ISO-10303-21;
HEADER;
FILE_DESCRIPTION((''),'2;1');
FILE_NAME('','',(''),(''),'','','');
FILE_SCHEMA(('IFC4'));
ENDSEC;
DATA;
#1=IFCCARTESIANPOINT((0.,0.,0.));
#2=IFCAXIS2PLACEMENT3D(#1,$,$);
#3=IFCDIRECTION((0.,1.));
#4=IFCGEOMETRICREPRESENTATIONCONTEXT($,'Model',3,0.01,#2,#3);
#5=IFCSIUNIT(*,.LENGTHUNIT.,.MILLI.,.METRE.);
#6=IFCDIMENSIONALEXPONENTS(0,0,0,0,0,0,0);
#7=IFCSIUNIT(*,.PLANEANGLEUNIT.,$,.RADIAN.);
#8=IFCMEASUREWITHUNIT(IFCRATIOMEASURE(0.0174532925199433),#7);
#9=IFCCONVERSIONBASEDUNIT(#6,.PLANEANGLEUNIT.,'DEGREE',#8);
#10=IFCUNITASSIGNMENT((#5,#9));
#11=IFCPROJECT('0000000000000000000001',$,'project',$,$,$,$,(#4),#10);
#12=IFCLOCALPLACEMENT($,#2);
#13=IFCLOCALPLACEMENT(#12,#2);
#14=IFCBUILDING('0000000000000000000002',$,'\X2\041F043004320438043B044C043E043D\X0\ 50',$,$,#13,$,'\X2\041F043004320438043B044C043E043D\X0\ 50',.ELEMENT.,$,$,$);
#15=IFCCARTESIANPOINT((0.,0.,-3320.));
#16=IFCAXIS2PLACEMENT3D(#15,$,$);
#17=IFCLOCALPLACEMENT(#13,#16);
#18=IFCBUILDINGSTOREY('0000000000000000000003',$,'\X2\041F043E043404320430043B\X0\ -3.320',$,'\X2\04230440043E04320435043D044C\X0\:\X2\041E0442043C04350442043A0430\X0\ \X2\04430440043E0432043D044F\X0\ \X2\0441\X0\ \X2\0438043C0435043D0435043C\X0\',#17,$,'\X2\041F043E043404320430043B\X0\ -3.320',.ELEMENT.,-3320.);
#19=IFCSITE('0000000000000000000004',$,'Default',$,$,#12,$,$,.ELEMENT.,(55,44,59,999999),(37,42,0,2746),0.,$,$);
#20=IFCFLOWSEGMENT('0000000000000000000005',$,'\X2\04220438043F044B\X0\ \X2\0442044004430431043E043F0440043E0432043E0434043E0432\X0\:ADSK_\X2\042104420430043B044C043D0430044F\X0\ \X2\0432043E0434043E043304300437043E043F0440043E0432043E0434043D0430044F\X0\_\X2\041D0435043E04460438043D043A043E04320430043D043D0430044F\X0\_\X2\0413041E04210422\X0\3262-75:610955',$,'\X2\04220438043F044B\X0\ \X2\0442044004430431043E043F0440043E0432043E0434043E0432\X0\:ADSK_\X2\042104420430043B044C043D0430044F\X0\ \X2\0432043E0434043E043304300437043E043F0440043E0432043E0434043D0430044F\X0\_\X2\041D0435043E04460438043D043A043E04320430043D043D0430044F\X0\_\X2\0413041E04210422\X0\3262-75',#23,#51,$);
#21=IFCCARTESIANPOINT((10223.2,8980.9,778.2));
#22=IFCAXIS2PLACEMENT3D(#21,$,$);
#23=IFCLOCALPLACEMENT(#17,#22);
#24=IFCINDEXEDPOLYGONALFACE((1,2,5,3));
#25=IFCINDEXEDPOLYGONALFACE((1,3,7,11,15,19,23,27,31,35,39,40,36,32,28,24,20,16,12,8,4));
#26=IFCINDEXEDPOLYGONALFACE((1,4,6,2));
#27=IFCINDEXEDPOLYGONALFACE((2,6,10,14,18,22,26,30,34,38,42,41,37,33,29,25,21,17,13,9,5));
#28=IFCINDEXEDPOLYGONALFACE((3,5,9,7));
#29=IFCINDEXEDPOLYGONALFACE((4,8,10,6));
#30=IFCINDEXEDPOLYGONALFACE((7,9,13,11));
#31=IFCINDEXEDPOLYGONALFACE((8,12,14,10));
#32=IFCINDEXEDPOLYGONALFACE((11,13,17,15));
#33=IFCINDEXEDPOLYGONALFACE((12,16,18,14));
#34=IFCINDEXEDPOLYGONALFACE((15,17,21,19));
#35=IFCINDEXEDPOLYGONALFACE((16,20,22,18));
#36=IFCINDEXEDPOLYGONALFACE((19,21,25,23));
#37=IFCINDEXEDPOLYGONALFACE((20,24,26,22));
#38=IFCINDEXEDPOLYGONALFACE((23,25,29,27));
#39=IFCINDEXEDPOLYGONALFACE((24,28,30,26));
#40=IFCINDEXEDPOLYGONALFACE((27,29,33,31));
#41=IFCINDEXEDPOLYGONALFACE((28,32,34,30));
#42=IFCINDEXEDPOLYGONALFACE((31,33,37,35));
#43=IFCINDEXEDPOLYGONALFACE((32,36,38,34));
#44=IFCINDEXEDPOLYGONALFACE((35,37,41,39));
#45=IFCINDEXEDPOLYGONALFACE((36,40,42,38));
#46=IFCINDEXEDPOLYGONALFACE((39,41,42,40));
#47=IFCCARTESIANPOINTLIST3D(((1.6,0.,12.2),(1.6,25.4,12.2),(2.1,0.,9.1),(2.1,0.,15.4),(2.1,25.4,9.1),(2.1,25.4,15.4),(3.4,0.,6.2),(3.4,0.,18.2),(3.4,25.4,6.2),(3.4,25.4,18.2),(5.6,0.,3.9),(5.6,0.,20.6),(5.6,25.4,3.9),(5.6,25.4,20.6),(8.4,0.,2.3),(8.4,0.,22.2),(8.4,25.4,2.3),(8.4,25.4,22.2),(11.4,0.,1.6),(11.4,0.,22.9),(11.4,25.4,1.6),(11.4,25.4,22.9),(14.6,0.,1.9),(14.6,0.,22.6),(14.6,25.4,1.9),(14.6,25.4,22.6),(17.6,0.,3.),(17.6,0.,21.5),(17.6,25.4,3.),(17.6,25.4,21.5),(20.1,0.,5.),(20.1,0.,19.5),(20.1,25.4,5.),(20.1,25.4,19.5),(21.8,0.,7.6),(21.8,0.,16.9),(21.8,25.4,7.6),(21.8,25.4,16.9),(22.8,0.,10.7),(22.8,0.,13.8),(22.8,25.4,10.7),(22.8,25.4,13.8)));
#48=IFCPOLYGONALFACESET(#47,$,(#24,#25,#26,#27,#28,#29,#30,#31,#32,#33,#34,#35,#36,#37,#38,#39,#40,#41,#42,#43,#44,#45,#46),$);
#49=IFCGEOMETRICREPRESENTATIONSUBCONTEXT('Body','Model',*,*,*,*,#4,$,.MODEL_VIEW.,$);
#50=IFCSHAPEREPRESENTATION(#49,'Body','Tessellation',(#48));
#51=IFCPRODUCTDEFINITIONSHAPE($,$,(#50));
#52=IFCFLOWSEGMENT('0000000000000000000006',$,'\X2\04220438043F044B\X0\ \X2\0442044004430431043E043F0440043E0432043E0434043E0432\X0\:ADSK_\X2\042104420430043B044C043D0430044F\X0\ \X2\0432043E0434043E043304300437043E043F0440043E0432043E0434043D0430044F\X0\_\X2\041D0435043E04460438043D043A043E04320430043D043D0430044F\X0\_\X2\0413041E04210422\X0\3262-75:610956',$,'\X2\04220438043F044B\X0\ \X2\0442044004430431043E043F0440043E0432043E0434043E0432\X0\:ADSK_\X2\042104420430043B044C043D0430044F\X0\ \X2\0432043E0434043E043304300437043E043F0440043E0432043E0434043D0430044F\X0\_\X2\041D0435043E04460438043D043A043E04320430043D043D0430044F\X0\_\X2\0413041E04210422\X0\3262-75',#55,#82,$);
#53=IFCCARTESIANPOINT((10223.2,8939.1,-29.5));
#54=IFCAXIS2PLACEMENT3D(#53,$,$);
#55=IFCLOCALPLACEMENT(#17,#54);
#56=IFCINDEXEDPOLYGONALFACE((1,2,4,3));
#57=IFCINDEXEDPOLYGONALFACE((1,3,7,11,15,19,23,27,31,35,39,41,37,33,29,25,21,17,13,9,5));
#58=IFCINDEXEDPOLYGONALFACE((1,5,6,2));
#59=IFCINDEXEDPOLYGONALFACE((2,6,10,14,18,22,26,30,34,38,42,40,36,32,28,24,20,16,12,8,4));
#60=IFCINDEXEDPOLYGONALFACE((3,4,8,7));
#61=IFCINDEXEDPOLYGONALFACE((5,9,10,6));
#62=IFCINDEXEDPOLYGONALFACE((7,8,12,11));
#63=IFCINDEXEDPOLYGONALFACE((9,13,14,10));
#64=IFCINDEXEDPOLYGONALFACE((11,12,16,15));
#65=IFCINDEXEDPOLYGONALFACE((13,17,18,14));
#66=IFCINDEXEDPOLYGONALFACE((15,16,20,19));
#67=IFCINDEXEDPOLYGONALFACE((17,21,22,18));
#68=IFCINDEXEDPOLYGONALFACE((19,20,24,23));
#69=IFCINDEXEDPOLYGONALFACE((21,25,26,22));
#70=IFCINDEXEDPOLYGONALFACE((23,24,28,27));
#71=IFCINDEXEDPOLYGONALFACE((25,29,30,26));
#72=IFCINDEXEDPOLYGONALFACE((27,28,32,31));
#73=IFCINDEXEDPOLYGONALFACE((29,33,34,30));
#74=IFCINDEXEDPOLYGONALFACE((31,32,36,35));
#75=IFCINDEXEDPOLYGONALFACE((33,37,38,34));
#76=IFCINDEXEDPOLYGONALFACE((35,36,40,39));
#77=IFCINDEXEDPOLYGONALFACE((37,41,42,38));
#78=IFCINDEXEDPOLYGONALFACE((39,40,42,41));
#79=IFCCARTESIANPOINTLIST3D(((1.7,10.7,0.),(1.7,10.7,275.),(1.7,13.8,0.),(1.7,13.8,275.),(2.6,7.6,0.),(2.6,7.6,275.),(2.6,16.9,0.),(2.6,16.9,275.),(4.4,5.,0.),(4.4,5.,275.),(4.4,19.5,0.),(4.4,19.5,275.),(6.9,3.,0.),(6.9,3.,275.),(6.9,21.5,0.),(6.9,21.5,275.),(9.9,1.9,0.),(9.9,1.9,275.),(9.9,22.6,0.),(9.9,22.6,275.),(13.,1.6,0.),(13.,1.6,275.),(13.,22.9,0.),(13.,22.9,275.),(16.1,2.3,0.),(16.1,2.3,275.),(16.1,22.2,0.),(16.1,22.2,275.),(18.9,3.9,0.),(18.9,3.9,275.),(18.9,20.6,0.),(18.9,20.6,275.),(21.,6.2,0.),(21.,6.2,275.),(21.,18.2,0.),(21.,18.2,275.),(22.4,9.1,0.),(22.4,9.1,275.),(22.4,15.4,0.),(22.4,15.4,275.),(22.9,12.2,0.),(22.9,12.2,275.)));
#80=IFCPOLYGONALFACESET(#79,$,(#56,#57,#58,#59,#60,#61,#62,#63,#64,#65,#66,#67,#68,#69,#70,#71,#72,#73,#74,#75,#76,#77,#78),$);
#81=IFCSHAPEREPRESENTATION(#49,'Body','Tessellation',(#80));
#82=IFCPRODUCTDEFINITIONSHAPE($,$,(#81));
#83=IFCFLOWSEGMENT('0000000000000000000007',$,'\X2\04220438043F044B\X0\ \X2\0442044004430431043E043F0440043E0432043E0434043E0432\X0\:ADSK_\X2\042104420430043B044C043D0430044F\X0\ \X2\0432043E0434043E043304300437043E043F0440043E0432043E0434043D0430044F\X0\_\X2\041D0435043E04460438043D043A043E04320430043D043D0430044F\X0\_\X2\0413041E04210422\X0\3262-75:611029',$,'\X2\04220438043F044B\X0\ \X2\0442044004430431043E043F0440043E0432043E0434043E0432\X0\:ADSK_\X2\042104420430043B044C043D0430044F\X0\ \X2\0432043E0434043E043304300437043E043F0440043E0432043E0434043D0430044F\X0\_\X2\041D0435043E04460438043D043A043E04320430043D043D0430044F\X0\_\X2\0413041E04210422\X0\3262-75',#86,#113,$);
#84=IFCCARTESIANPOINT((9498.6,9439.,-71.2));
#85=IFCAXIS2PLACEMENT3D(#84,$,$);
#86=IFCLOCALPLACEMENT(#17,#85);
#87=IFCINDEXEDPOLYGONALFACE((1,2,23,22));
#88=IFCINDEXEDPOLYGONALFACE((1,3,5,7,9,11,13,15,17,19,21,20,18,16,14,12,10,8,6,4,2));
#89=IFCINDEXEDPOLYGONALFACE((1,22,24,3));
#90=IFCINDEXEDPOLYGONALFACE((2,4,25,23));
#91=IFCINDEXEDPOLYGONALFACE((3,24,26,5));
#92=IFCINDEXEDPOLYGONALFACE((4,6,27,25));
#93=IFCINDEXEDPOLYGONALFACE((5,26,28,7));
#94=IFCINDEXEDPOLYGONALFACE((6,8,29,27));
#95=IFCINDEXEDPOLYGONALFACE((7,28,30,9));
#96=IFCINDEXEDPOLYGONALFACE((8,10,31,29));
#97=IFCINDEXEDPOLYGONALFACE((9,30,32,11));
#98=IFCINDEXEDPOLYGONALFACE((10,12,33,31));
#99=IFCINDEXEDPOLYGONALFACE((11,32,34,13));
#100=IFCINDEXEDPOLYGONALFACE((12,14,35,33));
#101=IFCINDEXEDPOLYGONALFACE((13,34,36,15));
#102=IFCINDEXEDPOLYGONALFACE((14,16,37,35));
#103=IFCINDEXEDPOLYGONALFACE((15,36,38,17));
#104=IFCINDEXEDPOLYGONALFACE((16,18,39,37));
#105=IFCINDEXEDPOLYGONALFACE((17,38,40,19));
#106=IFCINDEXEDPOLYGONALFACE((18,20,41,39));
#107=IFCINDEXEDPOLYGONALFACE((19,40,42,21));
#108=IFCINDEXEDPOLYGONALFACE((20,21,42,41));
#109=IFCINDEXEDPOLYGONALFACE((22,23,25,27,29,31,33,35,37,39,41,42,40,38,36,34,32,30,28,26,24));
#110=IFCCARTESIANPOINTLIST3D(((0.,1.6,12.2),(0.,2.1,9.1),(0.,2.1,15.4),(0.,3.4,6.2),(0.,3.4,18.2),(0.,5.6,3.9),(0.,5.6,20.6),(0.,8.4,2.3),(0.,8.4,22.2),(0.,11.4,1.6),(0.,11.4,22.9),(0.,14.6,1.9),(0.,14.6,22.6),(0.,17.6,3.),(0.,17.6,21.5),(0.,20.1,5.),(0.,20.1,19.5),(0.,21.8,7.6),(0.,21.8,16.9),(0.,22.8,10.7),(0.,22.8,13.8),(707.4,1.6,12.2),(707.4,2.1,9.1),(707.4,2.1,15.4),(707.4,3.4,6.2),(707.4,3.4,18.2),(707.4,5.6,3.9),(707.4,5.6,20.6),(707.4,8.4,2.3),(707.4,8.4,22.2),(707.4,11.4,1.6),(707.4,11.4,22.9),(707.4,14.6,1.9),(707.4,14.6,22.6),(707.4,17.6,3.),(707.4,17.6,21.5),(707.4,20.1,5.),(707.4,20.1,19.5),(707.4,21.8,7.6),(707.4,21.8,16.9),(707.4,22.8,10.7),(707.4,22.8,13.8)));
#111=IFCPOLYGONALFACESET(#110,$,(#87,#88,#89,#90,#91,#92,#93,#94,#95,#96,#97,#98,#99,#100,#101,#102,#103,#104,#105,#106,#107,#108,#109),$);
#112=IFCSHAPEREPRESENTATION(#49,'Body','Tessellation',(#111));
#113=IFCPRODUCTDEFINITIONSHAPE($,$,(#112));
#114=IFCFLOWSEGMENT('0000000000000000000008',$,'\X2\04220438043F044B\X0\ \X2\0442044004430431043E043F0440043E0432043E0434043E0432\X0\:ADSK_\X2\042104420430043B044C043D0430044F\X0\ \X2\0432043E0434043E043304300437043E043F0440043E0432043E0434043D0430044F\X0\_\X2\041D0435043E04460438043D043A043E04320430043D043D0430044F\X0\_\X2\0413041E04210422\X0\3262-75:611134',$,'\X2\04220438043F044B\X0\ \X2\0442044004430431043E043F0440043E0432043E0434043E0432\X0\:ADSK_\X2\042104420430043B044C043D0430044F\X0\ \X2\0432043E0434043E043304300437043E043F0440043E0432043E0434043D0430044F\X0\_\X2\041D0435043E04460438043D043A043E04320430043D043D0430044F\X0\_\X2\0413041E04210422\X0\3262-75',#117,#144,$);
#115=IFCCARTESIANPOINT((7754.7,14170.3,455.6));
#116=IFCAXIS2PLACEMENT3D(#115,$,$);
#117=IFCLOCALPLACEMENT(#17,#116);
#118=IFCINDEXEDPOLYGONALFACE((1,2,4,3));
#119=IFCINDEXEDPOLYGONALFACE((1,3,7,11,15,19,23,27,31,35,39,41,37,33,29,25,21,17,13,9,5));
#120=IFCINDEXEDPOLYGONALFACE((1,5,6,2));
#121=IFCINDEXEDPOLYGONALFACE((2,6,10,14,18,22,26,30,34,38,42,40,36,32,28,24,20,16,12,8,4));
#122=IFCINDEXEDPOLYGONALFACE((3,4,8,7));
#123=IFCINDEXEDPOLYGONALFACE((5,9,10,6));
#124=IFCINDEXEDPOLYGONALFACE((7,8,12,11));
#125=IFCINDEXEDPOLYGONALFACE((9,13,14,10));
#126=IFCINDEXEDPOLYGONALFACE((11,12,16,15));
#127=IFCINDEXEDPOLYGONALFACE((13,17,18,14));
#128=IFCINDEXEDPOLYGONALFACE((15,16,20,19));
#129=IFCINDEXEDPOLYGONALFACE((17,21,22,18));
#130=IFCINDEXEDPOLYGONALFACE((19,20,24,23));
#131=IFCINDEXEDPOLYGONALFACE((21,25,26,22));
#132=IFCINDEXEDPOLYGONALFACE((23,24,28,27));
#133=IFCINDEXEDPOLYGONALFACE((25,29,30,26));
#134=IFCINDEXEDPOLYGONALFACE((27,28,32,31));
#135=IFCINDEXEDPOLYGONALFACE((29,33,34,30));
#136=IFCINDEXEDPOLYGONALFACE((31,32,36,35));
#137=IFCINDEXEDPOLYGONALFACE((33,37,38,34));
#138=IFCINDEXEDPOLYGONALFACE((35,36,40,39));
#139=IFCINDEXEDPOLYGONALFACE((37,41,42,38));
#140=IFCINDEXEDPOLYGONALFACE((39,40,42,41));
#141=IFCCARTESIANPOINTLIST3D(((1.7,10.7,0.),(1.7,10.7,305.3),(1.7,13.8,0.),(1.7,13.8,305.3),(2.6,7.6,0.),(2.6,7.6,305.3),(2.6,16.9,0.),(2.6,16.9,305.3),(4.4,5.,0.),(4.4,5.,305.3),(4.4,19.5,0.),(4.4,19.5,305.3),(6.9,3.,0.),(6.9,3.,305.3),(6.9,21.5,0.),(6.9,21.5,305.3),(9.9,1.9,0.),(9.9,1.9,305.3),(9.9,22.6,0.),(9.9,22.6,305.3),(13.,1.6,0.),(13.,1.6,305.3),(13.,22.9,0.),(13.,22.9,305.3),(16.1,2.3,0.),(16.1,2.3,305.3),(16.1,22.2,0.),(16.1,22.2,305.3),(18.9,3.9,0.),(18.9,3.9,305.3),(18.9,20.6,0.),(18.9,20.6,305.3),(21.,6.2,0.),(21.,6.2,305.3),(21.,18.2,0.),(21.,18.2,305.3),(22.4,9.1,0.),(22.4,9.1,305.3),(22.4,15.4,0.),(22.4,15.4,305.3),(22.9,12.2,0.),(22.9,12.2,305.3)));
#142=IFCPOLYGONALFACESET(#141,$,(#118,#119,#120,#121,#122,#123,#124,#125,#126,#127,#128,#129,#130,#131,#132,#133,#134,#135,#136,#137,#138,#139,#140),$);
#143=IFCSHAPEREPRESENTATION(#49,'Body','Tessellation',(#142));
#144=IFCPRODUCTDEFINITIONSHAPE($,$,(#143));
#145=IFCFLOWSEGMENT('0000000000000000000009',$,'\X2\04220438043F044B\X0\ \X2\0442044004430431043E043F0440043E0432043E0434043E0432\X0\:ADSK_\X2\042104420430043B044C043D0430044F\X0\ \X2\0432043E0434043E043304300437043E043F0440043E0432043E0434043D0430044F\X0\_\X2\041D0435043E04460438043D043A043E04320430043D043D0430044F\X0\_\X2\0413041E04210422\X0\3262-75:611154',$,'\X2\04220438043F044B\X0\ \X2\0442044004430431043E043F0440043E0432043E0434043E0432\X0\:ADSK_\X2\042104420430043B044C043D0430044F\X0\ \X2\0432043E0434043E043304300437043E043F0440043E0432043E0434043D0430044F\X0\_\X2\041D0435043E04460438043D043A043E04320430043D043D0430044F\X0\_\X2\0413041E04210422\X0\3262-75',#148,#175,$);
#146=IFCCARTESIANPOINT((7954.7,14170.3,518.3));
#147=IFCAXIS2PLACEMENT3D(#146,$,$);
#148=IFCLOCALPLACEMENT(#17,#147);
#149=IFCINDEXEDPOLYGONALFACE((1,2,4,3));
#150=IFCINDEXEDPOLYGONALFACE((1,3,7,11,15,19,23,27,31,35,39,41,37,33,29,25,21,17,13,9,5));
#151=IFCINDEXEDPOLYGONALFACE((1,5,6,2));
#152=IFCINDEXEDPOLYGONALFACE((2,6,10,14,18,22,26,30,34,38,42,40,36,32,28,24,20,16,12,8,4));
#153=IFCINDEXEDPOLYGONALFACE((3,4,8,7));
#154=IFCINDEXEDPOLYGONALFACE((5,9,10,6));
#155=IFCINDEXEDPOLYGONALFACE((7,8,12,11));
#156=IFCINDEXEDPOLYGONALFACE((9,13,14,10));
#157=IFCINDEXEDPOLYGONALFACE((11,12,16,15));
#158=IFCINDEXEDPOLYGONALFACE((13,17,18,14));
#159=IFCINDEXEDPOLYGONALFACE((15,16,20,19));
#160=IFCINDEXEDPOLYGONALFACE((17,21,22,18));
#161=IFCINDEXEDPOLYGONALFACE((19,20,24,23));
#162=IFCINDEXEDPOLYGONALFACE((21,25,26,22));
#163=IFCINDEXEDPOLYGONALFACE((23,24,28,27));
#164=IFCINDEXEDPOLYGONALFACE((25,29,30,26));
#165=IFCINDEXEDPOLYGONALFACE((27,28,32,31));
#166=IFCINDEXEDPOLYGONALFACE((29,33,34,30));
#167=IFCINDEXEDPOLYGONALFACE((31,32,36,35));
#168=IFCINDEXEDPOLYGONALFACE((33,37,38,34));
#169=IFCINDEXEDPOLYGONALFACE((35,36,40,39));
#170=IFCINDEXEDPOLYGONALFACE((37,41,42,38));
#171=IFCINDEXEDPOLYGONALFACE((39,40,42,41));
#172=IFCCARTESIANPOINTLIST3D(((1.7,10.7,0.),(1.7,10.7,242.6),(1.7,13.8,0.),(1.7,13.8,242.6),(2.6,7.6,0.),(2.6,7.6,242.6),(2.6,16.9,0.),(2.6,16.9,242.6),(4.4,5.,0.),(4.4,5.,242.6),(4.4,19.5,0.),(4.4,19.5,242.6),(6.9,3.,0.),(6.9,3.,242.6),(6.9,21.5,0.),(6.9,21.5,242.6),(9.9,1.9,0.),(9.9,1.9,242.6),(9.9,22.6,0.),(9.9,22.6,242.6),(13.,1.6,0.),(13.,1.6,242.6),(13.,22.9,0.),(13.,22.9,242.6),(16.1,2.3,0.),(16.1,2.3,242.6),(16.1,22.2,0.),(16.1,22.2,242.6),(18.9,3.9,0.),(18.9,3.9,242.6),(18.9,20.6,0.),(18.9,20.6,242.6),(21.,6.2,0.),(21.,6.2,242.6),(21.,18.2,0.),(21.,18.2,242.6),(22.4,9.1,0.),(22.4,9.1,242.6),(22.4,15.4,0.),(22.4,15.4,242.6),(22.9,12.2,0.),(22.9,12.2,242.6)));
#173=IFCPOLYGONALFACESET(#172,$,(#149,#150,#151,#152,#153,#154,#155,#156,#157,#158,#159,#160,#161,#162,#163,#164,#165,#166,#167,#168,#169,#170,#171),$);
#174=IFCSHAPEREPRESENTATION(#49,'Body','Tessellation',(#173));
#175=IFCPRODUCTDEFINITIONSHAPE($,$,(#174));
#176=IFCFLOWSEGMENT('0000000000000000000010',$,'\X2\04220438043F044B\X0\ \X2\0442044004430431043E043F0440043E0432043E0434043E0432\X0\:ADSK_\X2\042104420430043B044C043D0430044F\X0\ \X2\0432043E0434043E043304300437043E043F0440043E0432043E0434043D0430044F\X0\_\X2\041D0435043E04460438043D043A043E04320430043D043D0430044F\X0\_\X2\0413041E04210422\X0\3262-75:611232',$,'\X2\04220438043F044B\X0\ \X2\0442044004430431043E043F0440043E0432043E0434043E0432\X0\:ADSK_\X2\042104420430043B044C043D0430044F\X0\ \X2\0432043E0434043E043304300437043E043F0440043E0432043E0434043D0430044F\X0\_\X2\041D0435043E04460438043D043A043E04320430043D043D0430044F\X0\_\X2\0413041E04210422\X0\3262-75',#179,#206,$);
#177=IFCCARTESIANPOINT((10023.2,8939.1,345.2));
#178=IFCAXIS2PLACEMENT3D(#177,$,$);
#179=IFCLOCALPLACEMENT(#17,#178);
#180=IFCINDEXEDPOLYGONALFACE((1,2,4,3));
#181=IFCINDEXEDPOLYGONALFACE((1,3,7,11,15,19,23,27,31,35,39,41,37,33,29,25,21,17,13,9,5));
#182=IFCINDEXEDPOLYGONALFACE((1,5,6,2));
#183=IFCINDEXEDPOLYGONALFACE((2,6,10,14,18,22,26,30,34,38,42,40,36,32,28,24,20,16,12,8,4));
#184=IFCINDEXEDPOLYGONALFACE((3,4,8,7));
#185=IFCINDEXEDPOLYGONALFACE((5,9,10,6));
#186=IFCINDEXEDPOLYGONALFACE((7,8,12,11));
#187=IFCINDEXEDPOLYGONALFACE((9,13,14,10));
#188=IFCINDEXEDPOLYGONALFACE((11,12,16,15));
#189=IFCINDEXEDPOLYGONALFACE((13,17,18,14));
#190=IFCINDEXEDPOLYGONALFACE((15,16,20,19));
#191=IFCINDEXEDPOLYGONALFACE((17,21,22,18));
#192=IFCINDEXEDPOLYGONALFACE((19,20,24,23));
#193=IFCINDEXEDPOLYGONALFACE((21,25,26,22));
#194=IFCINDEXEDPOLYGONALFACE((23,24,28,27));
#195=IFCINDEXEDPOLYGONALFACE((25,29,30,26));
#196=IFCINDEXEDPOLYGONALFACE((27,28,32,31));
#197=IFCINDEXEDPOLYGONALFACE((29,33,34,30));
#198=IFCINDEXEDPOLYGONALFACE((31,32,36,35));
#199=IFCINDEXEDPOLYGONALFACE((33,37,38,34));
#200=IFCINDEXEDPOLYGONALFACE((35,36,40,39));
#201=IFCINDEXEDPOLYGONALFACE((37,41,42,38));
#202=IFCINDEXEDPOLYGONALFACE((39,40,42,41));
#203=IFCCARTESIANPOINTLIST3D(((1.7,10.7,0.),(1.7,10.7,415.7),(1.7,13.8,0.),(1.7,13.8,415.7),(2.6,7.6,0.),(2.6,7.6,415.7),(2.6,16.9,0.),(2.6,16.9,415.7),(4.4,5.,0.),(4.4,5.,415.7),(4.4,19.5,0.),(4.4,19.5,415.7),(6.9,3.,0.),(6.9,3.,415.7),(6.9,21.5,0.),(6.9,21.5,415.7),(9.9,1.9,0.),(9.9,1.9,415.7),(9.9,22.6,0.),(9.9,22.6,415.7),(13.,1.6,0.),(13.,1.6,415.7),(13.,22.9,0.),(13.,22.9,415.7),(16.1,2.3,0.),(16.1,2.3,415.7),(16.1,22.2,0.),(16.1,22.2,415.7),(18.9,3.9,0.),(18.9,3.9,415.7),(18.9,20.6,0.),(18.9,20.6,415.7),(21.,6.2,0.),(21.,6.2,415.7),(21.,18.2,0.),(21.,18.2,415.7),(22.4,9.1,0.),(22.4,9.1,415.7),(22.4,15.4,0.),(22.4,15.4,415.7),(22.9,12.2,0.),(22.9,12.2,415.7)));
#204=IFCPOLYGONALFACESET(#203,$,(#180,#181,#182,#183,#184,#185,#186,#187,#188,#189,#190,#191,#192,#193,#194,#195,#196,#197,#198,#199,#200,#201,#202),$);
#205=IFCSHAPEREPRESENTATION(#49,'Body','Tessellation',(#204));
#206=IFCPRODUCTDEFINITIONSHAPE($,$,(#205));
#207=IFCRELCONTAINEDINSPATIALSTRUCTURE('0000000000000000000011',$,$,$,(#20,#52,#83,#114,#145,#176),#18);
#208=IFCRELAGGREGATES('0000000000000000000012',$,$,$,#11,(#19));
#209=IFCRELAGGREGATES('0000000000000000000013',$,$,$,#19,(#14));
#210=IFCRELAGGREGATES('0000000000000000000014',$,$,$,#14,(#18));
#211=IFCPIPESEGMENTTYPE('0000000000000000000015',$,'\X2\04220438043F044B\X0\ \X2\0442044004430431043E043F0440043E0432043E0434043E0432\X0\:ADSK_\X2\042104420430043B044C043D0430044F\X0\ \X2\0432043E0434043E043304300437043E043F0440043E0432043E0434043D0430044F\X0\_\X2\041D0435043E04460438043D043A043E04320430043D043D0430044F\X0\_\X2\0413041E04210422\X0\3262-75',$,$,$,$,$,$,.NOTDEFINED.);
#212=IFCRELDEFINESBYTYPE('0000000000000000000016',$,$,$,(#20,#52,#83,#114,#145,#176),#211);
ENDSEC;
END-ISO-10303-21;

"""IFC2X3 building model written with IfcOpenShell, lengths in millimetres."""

from ifc_helpers import new_model, entity, si_unit, converted_unit, direction, frame, origin, origin_2d_with_axis, place, context, subcontext, project, spatial, circle, extrude, type_object, element, save


model = new_model("IFC2X3")

# Units and contexts
model_context = context("Model", 3, precision=0.01, world=origin(), true_north=direction((0.0, 1.0)))
body_context = subcontext(model_context, "Body", "Model", "MODEL_VIEW")
ifc_project = project(units=[si_unit("LENGTHUNIT", "METRE", prefix="MILLI"), converted_unit("PLANEANGLEUNIT", "DEGREE", entity("IfcRatioMeasure", 0.0174532925199433), si_unit("PLANEANGLEUNIT", "RADIAN"), dimensions=[0, 0, 0, 0, 0, 0, 0])], contexts=[model_context])

# Site, building, storey
site_placement = place(None, origin())
site = spatial("IfcSite", under=ifc_project, at=site_placement, Name="Default", CompositionType="ELEMENT", RefLatitude=(55, 44, 59, 999999), RefLongitude=(37, 42, 0, 2746), RefElevation=0.0)
building_placement = place(site_placement, origin())
building = spatial("IfcBuilding", under=site, at=building_placement, Name="Павильон 50", LongName="Павильон 50", CompositionType="ELEMENT")
storey_placement = place(building_placement, frame((0.0, 0.0, -3320.0)))
storey = spatial("IfcBuildingStorey", under=building, at=storey_placement, Name="Подвал -3.320", ObjectType="Уровень:Отметка уровня с именем", LongName="Подвал -3.320", CompositionType="ELEMENT", Elevation=-3320.0)

# Flow segments
pipe_segment_type = type_object("IfcPipeSegmentType", Name="Типы трубопроводов:ADSK_Стальная водогазопроводная_Неоцинкованная_ГОСТ3262-75", PredefinedType="NOTDEFINED")
flow_segment_1_placement = place(storey_placement, frame((10223.2, 8980.9, 778.2)))
element("IfcFlowSegment", 1, at=flow_segment_1_placement, inside=storey, type_object=pipe_segment_type, Name="Типы трубопроводов:ADSK_Стальная водогазопроводная_Неоцинкованная_ГОСТ3262-75:610955", ObjectType="Типы трубопроводов:ADSK_Стальная водогазопроводная_Неоцинкованная_ГОСТ3262-75", context=body_context, shape_type="SweptSolid", body=[
    extrude(circle(Radius=10.7, at=origin_2d_with_axis()), frame((12.2, 0.0, 12.2), z_axis=(0.0, 1.0, 0.0), x_axis=(-1.0, 0.0, 0.0)), (0.0, 0.0, 1.0), 25.4),
])
flow_segment_2_placement = place(storey_placement, frame((10223.2, 8939.1, -29.5)))
element("IfcFlowSegment", 2, at=flow_segment_2_placement, inside=storey, type_object=pipe_segment_type, Name="Типы трубопроводов:ADSK_Стальная водогазопроводная_Неоцинкованная_ГОСТ3262-75:610956", ObjectType="Типы трубопроводов:ADSK_Стальная водогазопроводная_Неоцинкованная_ГОСТ3262-75", context=body_context, shape_type="SweptSolid", body=[
    extrude(circle(Radius=10.7, at=origin_2d_with_axis()), frame((12.2, 12.2, 0.0)), (0.0, 0.0, 1.0), 275.0),
])
flow_segment_3_placement = place(storey_placement, frame((9498.6, 9439.0, -71.2)))
element("IfcFlowSegment", 3, at=flow_segment_3_placement, inside=storey, type_object=pipe_segment_type, Name="Типы трубопроводов:ADSK_Стальная водогазопроводная_Неоцинкованная_ГОСТ3262-75:611029", ObjectType="Типы трубопроводов:ADSK_Стальная водогазопроводная_Неоцинкованная_ГОСТ3262-75", context=body_context, shape_type="SweptSolid", body=[
    extrude(circle(Radius=10.7, at=origin_2d_with_axis()), frame((0.0, 12.2, 12.2), z_axis=(1.0, 0.0, 0.0), x_axis=(0.0, -1.0, 0.0)), (0.0, 0.0, 1.0), 707.4),
])
flow_segment_4_placement = place(storey_placement, frame((7754.7, 14170.3, 455.6)))
element("IfcFlowSegment", 4, at=flow_segment_4_placement, inside=storey, type_object=pipe_segment_type, Name="Типы трубопроводов:ADSK_Стальная водогазопроводная_Неоцинкованная_ГОСТ3262-75:611134", ObjectType="Типы трубопроводов:ADSK_Стальная водогазопроводная_Неоцинкованная_ГОСТ3262-75", context=body_context, shape_type="SweptSolid", body=[
    extrude(circle(Radius=10.7, at=origin_2d_with_axis()), frame((12.2, 12.2, 0.0)), (0.0, 0.0, 1.0), 305.3),
])
flow_segment_5_placement = place(storey_placement, frame((7954.7, 14170.3, 518.3)))
element("IfcFlowSegment", 5, at=flow_segment_5_placement, inside=storey, type_object=pipe_segment_type, Name="Типы трубопроводов:ADSK_Стальная водогазопроводная_Неоцинкованная_ГОСТ3262-75:611154", ObjectType="Типы трубопроводов:ADSK_Стальная водогазопроводная_Неоцинкованная_ГОСТ3262-75", context=body_context, shape_type="SweptSolid", body=[
    extrude(circle(Radius=10.7, at=origin_2d_with_axis()), frame((12.2, 12.2, 0.0)), (0.0, 0.0, 1.0), 242.6),
])
flow_segment_6_placement = place(storey_placement, frame((10023.2, 8939.1, 345.2)))
element("IfcFlowSegment", 6, at=flow_segment_6_placement, inside=storey, type_object=pipe_segment_type, Name="Типы трубопроводов:ADSK_Стальная водогазопроводная_Неоцинкованная_ГОСТ3262-75:611232", ObjectType="Типы трубопроводов:ADSK_Стальная водогазопроводная_Неоцинкованная_ГОСТ3262-75", context=body_context, shape_type="SweptSolid", body=[
    extrude(circle(Radius=10.7, at=origin_2d_with_axis()), frame((12.2, 12.2, 0.0)), (0.0, 0.0, 1.0), 415.7),
])

save(model, "model.ifc")
